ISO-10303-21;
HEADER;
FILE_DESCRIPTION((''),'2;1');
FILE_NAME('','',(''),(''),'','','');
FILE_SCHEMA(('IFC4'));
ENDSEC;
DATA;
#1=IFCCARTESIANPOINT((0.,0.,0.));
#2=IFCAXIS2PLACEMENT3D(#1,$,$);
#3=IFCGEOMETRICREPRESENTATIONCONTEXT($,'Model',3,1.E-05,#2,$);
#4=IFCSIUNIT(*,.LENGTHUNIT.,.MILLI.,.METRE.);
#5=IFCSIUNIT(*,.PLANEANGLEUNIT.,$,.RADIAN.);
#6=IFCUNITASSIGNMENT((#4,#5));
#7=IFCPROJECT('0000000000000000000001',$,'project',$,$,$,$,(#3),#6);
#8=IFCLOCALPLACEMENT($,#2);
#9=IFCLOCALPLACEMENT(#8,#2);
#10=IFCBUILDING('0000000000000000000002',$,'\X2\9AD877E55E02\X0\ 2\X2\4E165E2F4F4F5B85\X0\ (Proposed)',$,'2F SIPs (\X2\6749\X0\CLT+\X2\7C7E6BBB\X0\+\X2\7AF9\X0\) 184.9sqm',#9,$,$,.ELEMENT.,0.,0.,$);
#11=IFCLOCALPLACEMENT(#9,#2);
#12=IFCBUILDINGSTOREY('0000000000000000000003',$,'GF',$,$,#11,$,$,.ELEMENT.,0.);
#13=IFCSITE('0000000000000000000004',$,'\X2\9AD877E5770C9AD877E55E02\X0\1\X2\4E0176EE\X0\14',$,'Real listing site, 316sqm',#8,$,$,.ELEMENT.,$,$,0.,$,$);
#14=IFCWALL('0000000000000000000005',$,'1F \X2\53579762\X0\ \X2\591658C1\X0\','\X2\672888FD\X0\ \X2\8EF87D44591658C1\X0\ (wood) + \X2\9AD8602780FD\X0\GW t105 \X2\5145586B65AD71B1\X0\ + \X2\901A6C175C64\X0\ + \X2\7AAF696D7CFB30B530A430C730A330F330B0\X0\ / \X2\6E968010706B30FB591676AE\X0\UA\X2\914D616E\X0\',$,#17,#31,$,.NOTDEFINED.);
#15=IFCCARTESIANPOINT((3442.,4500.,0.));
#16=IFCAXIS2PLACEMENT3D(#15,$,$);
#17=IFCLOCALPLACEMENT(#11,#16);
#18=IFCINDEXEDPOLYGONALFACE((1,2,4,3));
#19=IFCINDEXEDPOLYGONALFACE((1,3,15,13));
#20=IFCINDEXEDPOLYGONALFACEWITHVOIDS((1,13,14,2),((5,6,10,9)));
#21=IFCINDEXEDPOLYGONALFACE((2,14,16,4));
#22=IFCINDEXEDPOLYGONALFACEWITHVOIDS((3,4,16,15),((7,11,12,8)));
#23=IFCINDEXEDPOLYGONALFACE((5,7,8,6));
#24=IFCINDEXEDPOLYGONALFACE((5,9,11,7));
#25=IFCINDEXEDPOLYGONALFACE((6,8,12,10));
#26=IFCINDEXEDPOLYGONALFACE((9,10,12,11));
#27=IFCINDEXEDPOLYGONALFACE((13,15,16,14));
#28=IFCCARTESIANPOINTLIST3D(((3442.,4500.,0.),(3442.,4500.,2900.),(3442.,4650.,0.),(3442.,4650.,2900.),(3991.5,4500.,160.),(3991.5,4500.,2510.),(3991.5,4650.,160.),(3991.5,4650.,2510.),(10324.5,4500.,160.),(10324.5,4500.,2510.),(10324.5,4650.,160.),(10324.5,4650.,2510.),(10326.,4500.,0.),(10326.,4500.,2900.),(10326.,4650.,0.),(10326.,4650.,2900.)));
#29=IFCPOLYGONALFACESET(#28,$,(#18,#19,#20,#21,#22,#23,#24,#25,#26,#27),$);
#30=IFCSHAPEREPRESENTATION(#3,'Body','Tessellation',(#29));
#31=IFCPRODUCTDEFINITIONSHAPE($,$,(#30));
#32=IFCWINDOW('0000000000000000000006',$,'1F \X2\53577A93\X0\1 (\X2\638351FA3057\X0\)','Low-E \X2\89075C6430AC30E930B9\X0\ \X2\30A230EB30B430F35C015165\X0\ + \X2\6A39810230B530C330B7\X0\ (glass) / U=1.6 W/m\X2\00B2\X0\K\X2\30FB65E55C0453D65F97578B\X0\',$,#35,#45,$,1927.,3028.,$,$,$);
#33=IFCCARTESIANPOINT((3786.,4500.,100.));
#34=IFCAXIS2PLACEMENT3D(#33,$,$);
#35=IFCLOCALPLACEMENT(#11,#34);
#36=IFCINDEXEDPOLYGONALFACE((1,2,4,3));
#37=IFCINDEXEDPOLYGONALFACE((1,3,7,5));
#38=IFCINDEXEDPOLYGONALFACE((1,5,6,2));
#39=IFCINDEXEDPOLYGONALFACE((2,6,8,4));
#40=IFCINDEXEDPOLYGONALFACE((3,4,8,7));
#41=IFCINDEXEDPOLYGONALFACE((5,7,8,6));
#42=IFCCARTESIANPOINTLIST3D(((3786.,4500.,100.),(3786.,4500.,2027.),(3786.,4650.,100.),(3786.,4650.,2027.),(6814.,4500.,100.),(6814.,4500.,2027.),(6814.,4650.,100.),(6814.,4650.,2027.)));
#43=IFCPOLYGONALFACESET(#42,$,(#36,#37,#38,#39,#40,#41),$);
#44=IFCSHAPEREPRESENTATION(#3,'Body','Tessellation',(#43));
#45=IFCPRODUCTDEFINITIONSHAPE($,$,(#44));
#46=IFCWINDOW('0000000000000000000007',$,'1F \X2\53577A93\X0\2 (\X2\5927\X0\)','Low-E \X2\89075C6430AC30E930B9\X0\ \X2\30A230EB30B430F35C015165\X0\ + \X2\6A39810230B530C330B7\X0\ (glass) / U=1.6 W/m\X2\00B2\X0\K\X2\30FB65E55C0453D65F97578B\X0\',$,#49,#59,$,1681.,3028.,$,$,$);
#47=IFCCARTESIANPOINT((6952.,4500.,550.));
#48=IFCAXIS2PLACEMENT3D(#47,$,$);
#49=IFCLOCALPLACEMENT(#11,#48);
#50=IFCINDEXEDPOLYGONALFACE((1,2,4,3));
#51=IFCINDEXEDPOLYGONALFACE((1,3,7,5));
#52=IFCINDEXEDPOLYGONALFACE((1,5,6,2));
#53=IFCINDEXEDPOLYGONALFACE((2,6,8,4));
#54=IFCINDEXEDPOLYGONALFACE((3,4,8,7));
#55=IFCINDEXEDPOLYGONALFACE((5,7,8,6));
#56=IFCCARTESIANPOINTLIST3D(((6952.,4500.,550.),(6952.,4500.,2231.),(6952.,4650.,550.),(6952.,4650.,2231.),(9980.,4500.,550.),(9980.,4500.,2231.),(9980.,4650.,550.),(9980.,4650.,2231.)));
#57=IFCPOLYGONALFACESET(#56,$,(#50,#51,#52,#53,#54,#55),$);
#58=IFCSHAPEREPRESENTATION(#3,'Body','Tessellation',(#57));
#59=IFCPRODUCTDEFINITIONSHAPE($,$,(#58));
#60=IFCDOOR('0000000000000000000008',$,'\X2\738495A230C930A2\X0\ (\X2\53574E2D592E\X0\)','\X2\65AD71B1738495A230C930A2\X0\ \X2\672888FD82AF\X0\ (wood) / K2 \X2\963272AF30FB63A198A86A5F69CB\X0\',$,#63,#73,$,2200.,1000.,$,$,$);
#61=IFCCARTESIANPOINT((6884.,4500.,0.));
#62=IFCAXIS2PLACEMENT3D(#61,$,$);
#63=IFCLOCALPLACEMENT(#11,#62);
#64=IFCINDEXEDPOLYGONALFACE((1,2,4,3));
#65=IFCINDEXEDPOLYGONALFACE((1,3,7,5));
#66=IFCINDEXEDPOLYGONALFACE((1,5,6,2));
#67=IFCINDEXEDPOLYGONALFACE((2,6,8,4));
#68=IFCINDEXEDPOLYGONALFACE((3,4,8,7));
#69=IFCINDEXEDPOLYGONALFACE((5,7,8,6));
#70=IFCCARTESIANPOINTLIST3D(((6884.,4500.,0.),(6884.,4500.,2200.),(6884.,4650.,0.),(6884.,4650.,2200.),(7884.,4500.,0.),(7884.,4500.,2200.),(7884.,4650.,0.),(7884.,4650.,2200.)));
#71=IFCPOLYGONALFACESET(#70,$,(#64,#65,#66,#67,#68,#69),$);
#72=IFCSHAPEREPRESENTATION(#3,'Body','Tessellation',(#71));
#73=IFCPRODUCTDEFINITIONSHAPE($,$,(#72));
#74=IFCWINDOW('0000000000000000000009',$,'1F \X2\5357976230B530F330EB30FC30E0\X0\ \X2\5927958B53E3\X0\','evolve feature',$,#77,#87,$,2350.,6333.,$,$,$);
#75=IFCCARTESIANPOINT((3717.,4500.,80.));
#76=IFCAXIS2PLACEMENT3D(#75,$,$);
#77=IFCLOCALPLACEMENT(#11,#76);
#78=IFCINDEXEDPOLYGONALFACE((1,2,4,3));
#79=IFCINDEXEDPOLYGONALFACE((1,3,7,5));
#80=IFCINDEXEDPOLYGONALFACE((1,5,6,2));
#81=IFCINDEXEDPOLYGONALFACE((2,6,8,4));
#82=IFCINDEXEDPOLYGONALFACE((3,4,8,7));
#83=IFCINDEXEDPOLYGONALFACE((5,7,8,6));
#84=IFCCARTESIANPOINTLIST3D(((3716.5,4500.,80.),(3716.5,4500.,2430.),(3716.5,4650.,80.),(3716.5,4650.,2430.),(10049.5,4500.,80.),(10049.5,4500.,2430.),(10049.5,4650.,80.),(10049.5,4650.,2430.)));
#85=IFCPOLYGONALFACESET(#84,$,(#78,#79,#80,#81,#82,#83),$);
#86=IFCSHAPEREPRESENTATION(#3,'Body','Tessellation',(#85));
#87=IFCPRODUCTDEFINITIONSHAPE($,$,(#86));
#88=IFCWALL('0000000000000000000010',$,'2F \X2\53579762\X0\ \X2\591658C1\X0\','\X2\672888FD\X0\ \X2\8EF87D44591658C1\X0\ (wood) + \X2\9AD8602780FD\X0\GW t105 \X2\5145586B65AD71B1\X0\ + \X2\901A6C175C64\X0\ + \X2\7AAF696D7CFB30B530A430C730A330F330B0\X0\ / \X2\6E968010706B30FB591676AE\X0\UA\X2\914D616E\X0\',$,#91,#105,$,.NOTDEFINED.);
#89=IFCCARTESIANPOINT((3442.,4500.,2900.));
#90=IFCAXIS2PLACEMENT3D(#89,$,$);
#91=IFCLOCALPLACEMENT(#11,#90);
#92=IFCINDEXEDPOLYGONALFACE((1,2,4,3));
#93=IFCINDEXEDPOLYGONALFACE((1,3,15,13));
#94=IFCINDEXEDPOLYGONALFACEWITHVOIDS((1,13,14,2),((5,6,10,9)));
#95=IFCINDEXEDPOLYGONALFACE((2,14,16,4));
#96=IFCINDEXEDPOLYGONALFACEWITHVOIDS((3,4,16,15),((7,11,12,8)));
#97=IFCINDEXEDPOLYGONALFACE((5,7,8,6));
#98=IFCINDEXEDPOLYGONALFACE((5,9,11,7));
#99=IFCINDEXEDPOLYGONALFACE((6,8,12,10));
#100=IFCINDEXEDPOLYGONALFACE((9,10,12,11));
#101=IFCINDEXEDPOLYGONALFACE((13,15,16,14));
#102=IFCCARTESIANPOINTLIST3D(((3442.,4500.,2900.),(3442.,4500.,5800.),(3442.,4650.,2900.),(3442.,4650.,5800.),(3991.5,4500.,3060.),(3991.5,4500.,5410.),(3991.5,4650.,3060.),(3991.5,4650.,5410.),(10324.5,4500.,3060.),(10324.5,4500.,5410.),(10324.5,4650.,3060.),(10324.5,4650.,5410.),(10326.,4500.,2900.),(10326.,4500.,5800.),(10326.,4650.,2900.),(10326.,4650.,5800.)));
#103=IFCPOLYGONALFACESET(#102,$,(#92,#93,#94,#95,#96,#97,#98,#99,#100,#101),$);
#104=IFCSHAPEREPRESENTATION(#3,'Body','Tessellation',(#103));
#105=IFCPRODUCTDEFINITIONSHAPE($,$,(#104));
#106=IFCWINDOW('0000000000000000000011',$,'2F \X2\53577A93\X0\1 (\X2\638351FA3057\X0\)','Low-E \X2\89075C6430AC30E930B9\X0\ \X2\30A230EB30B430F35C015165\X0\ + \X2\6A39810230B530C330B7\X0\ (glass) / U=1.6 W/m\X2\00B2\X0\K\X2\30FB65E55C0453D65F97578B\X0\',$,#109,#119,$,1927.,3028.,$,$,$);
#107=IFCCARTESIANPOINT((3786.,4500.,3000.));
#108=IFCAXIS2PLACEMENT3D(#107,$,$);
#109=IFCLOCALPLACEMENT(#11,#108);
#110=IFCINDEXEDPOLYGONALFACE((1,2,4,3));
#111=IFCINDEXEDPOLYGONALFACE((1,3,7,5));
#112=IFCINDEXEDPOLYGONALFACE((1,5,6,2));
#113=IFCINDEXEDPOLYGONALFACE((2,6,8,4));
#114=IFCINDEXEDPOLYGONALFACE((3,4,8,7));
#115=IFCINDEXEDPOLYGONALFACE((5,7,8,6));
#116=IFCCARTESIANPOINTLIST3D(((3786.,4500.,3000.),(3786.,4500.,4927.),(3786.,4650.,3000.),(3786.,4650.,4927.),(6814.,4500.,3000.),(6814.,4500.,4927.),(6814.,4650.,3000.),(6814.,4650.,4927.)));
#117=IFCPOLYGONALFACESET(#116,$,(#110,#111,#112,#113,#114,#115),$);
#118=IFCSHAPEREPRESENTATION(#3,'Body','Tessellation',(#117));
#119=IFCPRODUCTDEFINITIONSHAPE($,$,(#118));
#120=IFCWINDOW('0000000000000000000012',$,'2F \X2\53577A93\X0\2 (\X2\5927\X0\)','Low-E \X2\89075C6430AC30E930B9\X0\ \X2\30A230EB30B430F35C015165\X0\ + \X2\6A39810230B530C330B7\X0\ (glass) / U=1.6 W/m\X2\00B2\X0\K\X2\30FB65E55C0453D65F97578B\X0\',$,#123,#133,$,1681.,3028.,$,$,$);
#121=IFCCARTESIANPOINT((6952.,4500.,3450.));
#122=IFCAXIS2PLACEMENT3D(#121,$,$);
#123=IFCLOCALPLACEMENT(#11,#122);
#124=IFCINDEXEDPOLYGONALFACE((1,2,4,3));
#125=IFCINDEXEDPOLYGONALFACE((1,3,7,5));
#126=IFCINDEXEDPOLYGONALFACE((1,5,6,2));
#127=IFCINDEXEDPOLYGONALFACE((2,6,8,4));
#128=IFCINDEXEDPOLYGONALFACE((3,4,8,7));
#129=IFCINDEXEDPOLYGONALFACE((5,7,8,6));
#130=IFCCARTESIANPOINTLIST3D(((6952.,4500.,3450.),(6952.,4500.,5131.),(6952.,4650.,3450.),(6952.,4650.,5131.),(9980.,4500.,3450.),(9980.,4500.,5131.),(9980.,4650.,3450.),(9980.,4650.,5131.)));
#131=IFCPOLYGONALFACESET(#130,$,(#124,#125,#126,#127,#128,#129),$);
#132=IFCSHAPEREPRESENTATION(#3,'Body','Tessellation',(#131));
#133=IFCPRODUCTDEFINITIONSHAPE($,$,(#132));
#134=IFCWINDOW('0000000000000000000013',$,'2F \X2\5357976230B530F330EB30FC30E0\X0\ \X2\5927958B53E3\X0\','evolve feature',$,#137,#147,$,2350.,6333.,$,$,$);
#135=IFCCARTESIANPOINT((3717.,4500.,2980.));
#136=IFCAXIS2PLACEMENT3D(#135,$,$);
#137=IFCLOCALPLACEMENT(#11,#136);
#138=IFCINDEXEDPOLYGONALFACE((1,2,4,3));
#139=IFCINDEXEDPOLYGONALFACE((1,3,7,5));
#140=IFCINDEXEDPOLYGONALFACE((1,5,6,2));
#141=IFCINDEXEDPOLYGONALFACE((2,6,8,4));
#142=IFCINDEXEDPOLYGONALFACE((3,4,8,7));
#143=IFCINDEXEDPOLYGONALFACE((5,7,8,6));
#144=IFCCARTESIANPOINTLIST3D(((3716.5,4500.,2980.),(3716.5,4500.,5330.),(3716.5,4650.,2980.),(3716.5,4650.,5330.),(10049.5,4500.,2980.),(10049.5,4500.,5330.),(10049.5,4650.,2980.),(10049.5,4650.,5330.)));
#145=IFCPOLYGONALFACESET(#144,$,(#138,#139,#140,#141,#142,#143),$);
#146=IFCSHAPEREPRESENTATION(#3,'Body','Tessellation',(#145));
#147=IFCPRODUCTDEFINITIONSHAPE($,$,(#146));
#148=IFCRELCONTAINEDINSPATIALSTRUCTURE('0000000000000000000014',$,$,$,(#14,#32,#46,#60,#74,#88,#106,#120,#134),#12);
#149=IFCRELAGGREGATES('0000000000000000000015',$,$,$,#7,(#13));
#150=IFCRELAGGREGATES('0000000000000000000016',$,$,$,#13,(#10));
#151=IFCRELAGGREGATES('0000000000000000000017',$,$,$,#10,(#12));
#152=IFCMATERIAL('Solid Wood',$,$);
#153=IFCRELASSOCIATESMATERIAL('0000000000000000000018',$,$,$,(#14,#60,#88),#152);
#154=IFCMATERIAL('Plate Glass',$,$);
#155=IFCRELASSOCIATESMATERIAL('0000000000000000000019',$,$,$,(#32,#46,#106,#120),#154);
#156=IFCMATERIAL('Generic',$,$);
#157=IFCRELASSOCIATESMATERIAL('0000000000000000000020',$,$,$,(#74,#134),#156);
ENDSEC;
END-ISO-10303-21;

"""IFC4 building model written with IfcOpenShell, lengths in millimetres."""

from ifc_helpers import new_model, si_unit, frame, frame_2d, origin, place, context, project, spatial, rectangle, extrude, material, element, fill, save


model = new_model("IFC4")

# Units and contexts
model_context = context("Model", 3, precision=1e-05, world=origin())
ifc_project = project(units=[si_unit("LENGTHUNIT", "METRE", prefix="MILLI"), si_unit("PLANEANGLEUNIT", "RADIAN")], contexts=[model_context])

# Site, building, storey
site_placement = place(None, origin())
site = spatial("IfcSite", under=ifc_project, at=site_placement, Name="高知県高知市1丁目14", ObjectType="Real listing site, 316sqm", CompositionType="ELEMENT", RefElevation=0.0)
building_placement = place(site_placement, origin())
building = spatial("IfcBuilding", under=site, at=building_placement, Name="高知市 2世帯住宅 (Proposed)", ObjectType="2F SIPs (杉CLT+籾殻+竹) 184.9sqm", CompositionType="ELEMENT", ElevationOfRefHeight=0.0, ElevationOfTerrain=0.0)
storey_placement = place(building_placement, origin())
storey = spatial("IfcBuildingStorey", under=building, at=storey_placement, Name="GF", CompositionType="ELEMENT", Elevation=0.0)

# Shared definitions
ifc_material_1 = material(Name="Solid Wood")

# Wall, openings, windows, door
wall_1_placement = place(storey_placement, frame((3442.0, 4500.0, 0.0)))
wall_1 = element("IfcWall", 1, at=wall_1_placement, inside=storey, material=ifc_material_1, Name="1F 南面 外壁", Description="木製 軸組外壁 (wood) + 高性能GW t105 充填断熱 + 通気層 + 窯業系サイディング / 準耐火・外皮UA配慮", PredefinedType="NOTDEFINED", context=model_context, shape_type="SweptSolid", body=[
    extrude(rectangle(XDim=6884.0, YDim=150.0, at=frame_2d((3442.0, 75.0))), frame((3442.0, 4500.0, 0.0)), (0.0, 0.0, 1.0), 2900.0),
])
opening_1_placement = place(storey_placement, frame((3786.0, 4500.0, 100.0)))
opening_1 = element("IfcOpeningElement", 2, at=opening_1_placement, cuts=wall_1, PredefinedType="NOTDEFINED", context=model_context, shape_type="SweptSolid", body=[
    extrude(rectangle(XDim=3028.0, YDim=150.0, at=frame_2d((1514.0, 75.0))), frame((3786.0, 4500.0, 100.0)), (0.0, 0.0, 1.0), 1927.0),
])
opening_2_placement = place(storey_placement, frame((6952.0, 4500.0, 550.0)))
opening_2 = element("IfcOpeningElement", 3, at=opening_2_placement, cuts=wall_1, PredefinedType="NOTDEFINED", context=model_context, shape_type="SweptSolid", body=[
    extrude(rectangle(XDim=3028.0, YDim=150.0, at=frame_2d((1514.0, 75.0))), frame((6952.0, 4500.0, 550.0)), (0.0, 0.0, 1.0), 1681.0),
])
opening_3_placement = place(storey_placement, frame((6884.0, 4500.0, 0.0)))
opening_3 = element("IfcOpeningElement", 4, at=opening_3_placement, cuts=wall_1, PredefinedType="NOTDEFINED", context=model_context, shape_type="SweptSolid", body=[
    extrude(rectangle(XDim=1000.0, YDim=150.0, at=frame_2d((500.0, 75.0))), frame((6884.0, 4500.0, 0.0)), (0.0, 0.0, 1.0), 2200.0),
])
opening_4_placement = place(storey_placement, frame((3717.0, 4500.0, 80.0)))
opening_4 = element("IfcOpeningElement", 5, at=opening_4_placement, cuts=wall_1, PredefinedType="NOTDEFINED", context=model_context, shape_type="SweptSolid", body=[
    extrude(rectangle(XDim=6333.0, YDim=150.0, at=frame_2d((3166.0, 75.0))), frame((3717.0, 4500.0, 80.0)), (0.0, 0.0, 1.0), 2350.0),
])
ifc_material_2 = material(Name="Plate Glass")
window_1_placement = place(storey_placement, frame((3786.0, 4500.0, 100.0)))
window_1 = element("IfcWindow", 6, at=window_1_placement, inside=storey, material=ifc_material_2, Name="1F 南窓1 (掃出し)", Description="Low-E 複層ガラス アルゴン封入 + 樹脂サッシ (glass) / U=1.6 W/m²K・日射取得型", OverallHeight=1927.0, OverallWidth=3028.0, context=model_context, shape_type="SweptSolid", body=[
    extrude(rectangle(XDim=3028.0, YDim=150.0, at=frame_2d((1514.0, 75.0))), frame((3786.0, 4500.0, 100.0)), (0.0, 0.0, 1.0), 1927.0),
])
fill(opening_1, window_1)
window_2_placement = place(storey_placement, frame((6952.0, 4500.0, 550.0)))
window_2 = element("IfcWindow", 7, at=window_2_placement, inside=storey, material=ifc_material_2, Name="1F 南窓2 (大)", Description="Low-E 複層ガラス アルゴン封入 + 樹脂サッシ (glass) / U=1.6 W/m²K・日射取得型", OverallHeight=1681.0, OverallWidth=3028.0, context=model_context, shape_type="SweptSolid", body=[
    extrude(rectangle(XDim=3028.0, YDim=150.0, at=frame_2d((1514.0, 75.0))), frame((6952.0, 4500.0, 550.0)), (0.0, 0.0, 1.0), 1681.0),
])
fill(opening_2, window_2)
door_placement = place(storey_placement, frame((6884.0, 4500.0, 0.0)))
door = element("IfcDoor", 8, at=door_placement, inside=storey, material=ifc_material_1, Name="玄関ドア (南中央)", Description="断熱玄関ドア 木製芯 (wood) / K2 防犯・採風機構", OverallHeight=2200.0, OverallWidth=1000.0, context=model_context, shape_type="SweptSolid", body=[
    extrude(rectangle(XDim=1000.0, YDim=150.0, at=frame_2d((500.0, 75.0))), frame((6884.0, 4500.0, 0.0)), (0.0, 0.0, 1.0), 2200.0),
])
fill(opening_3, door)
ifc_material_3 = material(Name="Generic")
window_3_placement = place(storey_placement, frame((3717.0, 4500.0, 80.0)))
window_3 = element("IfcWindow", 9, at=window_3_placement, inside=storey, material=ifc_material_3, Name="1F 南面サンルーム 大開口", Description="evolve feature", OverallHeight=2350.0, OverallWidth=6333.0, context=model_context, shape_type="SweptSolid", body=[
    extrude(rectangle(XDim=6333.0, YDim=150.0, at=frame_2d((3166.0, 75.0))), frame((3717.0, 4500.0, 80.0)), (0.0, 0.0, 1.0), 2350.0),
])
fill(opening_4, window_3)

# Wall, openings, windows
wall_2_placement = place(storey_placement, frame((3442.0, 4500.0, 2900.0)))
wall_2 = element("IfcWall", 10, at=wall_2_placement, inside=storey, material=ifc_material_1, Name="2F 南面 外壁", Description="木製 軸組外壁 (wood) + 高性能GW t105 充填断熱 + 通気層 + 窯業系サイディング / 準耐火・外皮UA配慮", PredefinedType="NOTDEFINED", context=model_context, shape_type="SweptSolid", body=[
    extrude(rectangle(XDim=6884.0, YDim=150.0, at=frame_2d((3442.0, 75.0))), frame((3442.0, 4500.0, 2900.0)), (0.0, 0.0, 1.0), 2900.0),
])
opening_5_placement = place(storey_placement, frame((3786.0, 4500.0, 3000.0)))
opening_5 = element("IfcOpeningElement", 11, at=opening_5_placement, cuts=wall_2, PredefinedType="NOTDEFINED", context=model_context, shape_type="SweptSolid", body=[
    extrude(rectangle(XDim=3028.0, YDim=150.0, at=frame_2d((1514.0, 75.0))), frame((3786.0, 4500.0, 3000.0)), (0.0, 0.0, 1.0), 1927.0),
])
opening_6_placement = place(storey_placement, frame((6952.0, 4500.0, 3450.0)))
opening_6 = element("IfcOpeningElement", 12, at=opening_6_placement, cuts=wall_2, PredefinedType="NOTDEFINED", context=model_context, shape_type="SweptSolid", body=[
    extrude(rectangle(XDim=3028.0, YDim=150.0, at=frame_2d((1514.0, 75.0))), frame((6952.0, 4500.0, 3450.0)), (0.0, 0.0, 1.0), 1681.0),
])
opening_7_placement = place(storey_placement, frame((3717.0, 4500.0, 2980.0)))
opening_7 = element("IfcOpeningElement", 13, at=opening_7_placement, cuts=wall_2, PredefinedType="NOTDEFINED", context=model_context, shape_type="SweptSolid", body=[
    extrude(rectangle(XDim=6333.0, YDim=150.0, at=frame_2d((3166.0, 75.0))), frame((3717.0, 4500.0, 2980.0)), (0.0, 0.0, 1.0), 2350.0),
])
window_4_placement = place(storey_placement, frame((3786.0, 4500.0, 3000.0)))
window_4 = element("IfcWindow", 14, at=window_4_placement, inside=storey, material=ifc_material_2, Name="2F 南窓1 (掃出し)", Description="Low-E 複層ガラス アルゴン封入 + 樹脂サッシ (glass) / U=1.6 W/m²K・日射取得型", OverallHeight=1927.0, OverallWidth=3028.0, context=model_context, shape_type="SweptSolid", body=[
    extrude(rectangle(XDim=3028.0, YDim=150.0, at=frame_2d((1514.0, 75.0))), frame((3786.0, 4500.0, 3000.0)), (0.0, 0.0, 1.0), 1927.0),
])
fill(opening_5, window_4)
window_5_placement = place(storey_placement, frame((6952.0, 4500.0, 3450.0)))
window_5 = element("IfcWindow", 15, at=window_5_placement, inside=storey, material=ifc_material_2, Name="2F 南窓2 (大)", Description="Low-E 複層ガラス アルゴン封入 + 樹脂サッシ (glass) / U=1.6 W/m²K・日射取得型", OverallHeight=1681.0, OverallWidth=3028.0, context=model_context, shape_type="SweptSolid", body=[
    extrude(rectangle(XDim=3028.0, YDim=150.0, at=frame_2d((1514.0, 75.0))), frame((6952.0, 4500.0, 3450.0)), (0.0, 0.0, 1.0), 1681.0),
])
fill(opening_6, window_5)
window_6_placement = place(storey_placement, frame((3717.0, 4500.0, 2980.0)))
window_6 = element("IfcWindow", 16, at=window_6_placement, inside=storey, material=ifc_material_3, Name="2F 南面サンルーム 大開口", Description="evolve feature", OverallHeight=2350.0, OverallWidth=6333.0, context=model_context, shape_type="SweptSolid", body=[
    extrude(rectangle(XDim=6333.0, YDim=150.0, at=frame_2d((3166.0, 75.0))), frame((3717.0, 4500.0, 2980.0)), (0.0, 0.0, 1.0), 2350.0),
])
fill(opening_7, window_6)

save(model, "model.ifc")
